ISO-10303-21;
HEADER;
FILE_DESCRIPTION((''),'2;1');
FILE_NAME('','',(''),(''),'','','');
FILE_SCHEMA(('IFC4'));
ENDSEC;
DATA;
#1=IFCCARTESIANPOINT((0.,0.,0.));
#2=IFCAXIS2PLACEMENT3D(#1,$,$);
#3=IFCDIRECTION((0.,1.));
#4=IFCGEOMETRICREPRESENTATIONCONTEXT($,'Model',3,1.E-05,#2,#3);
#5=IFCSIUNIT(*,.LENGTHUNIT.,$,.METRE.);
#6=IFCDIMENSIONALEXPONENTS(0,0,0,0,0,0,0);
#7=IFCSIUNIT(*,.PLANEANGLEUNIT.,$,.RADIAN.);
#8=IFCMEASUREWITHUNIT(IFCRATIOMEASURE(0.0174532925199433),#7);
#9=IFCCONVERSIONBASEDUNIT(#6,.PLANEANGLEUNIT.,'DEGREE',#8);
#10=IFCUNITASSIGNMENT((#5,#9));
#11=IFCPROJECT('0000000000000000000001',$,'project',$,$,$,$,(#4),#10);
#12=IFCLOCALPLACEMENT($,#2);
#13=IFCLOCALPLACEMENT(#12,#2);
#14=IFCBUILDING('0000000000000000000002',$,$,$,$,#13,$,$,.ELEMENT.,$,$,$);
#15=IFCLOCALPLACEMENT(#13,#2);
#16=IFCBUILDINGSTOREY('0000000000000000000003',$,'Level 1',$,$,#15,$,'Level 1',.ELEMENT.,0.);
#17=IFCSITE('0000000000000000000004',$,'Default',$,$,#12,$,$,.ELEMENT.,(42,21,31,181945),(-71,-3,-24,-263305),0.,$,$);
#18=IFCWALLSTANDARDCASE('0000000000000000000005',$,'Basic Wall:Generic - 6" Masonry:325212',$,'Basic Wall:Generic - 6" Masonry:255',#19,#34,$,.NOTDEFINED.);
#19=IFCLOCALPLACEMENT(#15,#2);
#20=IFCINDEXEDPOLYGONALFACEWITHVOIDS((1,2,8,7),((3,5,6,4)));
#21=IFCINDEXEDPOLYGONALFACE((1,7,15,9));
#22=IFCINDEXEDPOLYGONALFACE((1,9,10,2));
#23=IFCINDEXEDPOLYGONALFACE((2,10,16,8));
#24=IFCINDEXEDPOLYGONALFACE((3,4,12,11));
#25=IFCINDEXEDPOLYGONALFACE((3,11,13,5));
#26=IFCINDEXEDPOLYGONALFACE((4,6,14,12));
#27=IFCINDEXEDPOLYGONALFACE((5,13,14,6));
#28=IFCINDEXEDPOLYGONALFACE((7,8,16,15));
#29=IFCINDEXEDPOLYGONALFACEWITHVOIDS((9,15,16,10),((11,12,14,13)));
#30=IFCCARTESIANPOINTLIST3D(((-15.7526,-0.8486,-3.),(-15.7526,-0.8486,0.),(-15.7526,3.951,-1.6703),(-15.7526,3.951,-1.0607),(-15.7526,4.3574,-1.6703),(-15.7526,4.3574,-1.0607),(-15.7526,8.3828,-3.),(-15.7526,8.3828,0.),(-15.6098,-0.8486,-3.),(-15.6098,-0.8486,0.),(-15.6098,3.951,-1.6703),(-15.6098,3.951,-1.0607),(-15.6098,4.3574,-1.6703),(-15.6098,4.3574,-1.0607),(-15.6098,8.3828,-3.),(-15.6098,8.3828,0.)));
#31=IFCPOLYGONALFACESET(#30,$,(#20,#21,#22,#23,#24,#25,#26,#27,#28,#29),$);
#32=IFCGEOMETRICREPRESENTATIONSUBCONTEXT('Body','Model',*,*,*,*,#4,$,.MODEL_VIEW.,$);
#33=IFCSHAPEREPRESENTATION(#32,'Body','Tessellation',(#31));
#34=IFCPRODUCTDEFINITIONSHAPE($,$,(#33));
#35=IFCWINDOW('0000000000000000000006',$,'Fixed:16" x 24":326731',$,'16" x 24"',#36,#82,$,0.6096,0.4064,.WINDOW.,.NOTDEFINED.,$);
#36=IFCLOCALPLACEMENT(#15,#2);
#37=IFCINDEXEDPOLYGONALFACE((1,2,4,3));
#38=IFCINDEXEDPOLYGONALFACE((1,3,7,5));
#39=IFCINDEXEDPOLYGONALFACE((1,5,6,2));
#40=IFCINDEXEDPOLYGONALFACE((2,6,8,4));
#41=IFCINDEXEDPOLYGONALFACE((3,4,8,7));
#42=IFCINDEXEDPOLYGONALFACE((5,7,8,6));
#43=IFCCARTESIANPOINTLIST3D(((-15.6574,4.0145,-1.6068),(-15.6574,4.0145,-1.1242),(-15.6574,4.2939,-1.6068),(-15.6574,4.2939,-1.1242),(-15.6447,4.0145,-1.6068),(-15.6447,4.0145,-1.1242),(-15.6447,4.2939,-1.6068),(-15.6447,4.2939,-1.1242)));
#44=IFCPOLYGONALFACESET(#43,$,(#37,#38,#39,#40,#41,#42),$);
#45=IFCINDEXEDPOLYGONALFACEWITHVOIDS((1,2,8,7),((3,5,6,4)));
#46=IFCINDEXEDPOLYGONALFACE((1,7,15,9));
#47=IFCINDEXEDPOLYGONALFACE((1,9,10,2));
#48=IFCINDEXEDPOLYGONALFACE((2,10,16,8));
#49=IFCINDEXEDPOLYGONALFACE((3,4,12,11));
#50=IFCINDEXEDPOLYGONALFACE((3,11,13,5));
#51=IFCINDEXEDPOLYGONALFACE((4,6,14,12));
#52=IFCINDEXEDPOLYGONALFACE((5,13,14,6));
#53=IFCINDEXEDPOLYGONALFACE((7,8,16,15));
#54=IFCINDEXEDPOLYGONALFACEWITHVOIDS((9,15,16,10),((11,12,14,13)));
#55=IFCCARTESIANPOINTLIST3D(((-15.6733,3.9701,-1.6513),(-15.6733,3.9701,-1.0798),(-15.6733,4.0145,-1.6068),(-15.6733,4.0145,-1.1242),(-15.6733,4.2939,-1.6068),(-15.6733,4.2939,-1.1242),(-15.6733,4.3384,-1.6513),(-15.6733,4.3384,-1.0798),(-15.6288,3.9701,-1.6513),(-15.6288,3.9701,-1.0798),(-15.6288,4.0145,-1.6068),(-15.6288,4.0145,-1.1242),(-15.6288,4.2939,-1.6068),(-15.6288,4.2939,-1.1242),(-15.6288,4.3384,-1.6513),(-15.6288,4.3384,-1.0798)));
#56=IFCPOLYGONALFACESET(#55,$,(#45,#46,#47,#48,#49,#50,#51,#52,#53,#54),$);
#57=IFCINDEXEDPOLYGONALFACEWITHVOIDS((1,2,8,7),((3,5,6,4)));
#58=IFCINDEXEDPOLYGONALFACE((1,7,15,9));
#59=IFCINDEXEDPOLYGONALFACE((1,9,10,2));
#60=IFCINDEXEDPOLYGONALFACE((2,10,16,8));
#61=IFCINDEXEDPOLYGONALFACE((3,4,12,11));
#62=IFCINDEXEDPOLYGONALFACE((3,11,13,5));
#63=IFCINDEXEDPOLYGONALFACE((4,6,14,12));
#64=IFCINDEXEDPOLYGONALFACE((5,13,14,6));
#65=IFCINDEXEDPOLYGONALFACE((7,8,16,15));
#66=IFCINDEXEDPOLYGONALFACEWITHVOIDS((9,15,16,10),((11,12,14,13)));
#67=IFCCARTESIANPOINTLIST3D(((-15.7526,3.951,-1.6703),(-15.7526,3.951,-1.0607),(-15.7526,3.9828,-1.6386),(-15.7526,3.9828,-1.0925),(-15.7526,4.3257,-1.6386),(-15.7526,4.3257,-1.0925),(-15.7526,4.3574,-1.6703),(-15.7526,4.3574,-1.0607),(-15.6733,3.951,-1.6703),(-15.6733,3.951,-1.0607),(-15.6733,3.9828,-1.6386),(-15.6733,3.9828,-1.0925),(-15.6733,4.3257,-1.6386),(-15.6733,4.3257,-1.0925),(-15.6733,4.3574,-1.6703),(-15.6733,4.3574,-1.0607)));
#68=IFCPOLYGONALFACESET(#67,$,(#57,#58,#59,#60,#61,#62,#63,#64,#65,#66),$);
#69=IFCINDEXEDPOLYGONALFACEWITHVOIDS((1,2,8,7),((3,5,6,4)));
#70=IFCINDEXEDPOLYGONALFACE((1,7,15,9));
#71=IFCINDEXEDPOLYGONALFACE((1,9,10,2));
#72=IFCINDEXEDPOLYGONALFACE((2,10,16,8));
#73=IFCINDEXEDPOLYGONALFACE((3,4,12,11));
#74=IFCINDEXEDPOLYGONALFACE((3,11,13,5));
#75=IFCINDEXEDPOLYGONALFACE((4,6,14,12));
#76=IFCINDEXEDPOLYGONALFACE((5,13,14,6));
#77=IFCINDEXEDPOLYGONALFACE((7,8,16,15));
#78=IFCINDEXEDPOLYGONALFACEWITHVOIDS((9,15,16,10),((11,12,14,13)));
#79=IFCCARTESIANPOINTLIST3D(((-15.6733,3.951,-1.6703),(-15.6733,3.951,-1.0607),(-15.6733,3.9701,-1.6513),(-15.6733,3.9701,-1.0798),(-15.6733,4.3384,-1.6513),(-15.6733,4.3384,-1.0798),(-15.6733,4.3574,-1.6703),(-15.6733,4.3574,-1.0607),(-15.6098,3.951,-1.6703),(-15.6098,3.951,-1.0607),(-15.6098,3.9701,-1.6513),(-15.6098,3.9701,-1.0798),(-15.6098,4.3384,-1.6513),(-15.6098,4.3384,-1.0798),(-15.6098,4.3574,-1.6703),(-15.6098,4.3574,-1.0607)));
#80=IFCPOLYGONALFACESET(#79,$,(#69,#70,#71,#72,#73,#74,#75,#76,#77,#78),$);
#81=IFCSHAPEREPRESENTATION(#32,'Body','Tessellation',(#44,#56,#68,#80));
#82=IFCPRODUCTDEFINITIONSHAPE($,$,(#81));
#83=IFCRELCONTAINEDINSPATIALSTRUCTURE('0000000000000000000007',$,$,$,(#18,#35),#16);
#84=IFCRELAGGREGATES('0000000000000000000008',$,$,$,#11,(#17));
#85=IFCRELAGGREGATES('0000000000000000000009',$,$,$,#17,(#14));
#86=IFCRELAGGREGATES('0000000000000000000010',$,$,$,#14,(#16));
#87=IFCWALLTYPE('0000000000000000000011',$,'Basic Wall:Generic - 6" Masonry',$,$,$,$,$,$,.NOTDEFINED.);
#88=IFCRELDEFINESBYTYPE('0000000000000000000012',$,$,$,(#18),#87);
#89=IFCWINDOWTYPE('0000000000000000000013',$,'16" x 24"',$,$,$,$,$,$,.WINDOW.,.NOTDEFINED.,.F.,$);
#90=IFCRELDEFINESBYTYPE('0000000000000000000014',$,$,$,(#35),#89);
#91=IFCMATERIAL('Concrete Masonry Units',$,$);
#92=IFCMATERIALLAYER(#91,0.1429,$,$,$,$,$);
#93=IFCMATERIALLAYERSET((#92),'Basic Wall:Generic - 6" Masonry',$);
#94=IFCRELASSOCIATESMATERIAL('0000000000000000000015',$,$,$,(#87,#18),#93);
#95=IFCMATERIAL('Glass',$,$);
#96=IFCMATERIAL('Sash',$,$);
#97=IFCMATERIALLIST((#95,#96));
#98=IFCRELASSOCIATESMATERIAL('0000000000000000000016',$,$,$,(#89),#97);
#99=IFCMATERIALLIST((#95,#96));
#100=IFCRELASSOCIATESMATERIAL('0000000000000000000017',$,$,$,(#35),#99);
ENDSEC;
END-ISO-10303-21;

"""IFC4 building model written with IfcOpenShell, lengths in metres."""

from ifc_helpers import new_model, entity, si_unit, converted_unit, direction, frame, frame_2d, origin, place, context, subcontext, project, spatial, polyline, rectangle, outline, extrude, source, transform, mapped, material, material_list, layer, layer_set, layer_usage, type_object, type_shapes, element, fill, save


model = new_model("IFC4")

# Units and contexts
model_context = context("Model", 3, precision=1e-05, world=origin(), true_north=direction((0.0, 1.0)))
body_context = subcontext(model_context, "Body", "Model", "MODEL_VIEW")
ifc_project = project(units=[si_unit("LENGTHUNIT", "METRE"), converted_unit("PLANEANGLEUNIT", "DEGREE", entity("IfcRatioMeasure", 0.0174532925199433), si_unit("PLANEANGLEUNIT", "RADIAN"), dimensions=[0, 0, 0, 0, 0, 0, 0])], contexts=[model_context])

# Site, building, storey
site_placement = place(None, origin())
site = spatial("IfcSite", under=ifc_project, at=site_placement, Name="Default", CompositionType="ELEMENT", RefLatitude=(42, 21, 31, 181945), RefLongitude=(-71, -3, -24, -263305), RefElevation=0.0)
building_placement = place(site_placement, origin())
building = spatial("IfcBuilding", under=site, at=building_placement, CompositionType="ELEMENT")
storey_placement = place(building_placement, origin())
storey = spatial("IfcBuildingStorey", under=building, at=storey_placement, Name="Level 1", LongName="Level 1", CompositionType="ELEMENT", Elevation=0.0)

# Shared definitions
ifc_material_1 = material(Name="Concrete Masonry Units")
ifc_layer = layer(ifc_material_1, 0.1429)
ifc_layer_set = layer_set([ifc_layer], Name="Basic Wall:Generic - 6\" Masonry")
wall_type = type_object("IfcWallType", Name="Basic Wall:Generic - 6\" Masonry", PredefinedType="NOTDEFINED", material=ifc_layer_set)
ifc_material_2 = material(Name="Glass")
ifc_material_3 = material(Name="Sash")
ifc_material_list_1 = material_list([ifc_material_2, ifc_material_3])
window_type = type_object("IfcWindowType", Name="16\" x 24\"", ParameterTakesPrecedence=False, PartitioningType="NOTDEFINED", PredefinedType="WINDOW", material=ifc_material_list_1)
shared_shape = source(origin(), body_context, "Body", "SweptSolid", [
    extrude(rectangle(XDim=0.0127, YDim=0.2794, at=frame_2d((0.0, 0.0), x_axis=(1.0, 0.0))), frame((0.2032, 0.1016, 0.0635), z_axis=(0.0, 0.0, 1.0), x_axis=(0.0, 1.0, 0.0)), (0.0, 0.0, 1.0), 0.4826),
    extrude(outline(polyline([(-0.1841, -0.2858), (0.1841, -0.2858), (0.1841, 0.2858), (-0.1841, 0.2858), (-0.1841, -0.2858)]), holes=[polyline([(-0.1397, -0.2413), (-0.1397, 0.2413), (0.1397, 0.2413), (0.1397, -0.2413), (-0.1397, -0.2413)])]), frame((0.2032, 0.0794, 0.3048), z_axis=(0.0, 1.0, 0.0), x_axis=(1.0, 0.0, 0.0)), (0.0, 0.0, 1.0), 0.0445),
    extrude(outline(polyline([(-0.2032, -0.3048), (0.2032, -0.3048), (0.2032, 0.3048), (-0.2032, 0.3048), (-0.2032, -0.3048)]), holes=[polyline([(-0.1715, -0.273), (-0.1715, 0.2731), (0.1714, 0.2731), (0.1714, -0.273), (-0.1715, -0.273)])]), frame((0.2032, 0.0, 0.3048), z_axis=(0.0, 1.0, 0.0), x_axis=(1.0, 0.0, 0.0)), (0.0, 0.0, 1.0), 0.0794),
    extrude(outline(polyline([(-0.3048, -0.2032), (0.3048, -0.2032), (0.3048, 0.2032), (-0.3048, 0.2032), (-0.3048, -0.2032)]), holes=[polyline([(-0.2857, -0.1841), (-0.2857, 0.1842), (0.2858, 0.1842), (0.2858, -0.1841), (-0.2857, -0.1841)])]), frame((0.2032, 0.0794, 0.3048), z_axis=(0.0, 1.0, 0.0), x_axis=(0.0, 0.0, -1.0)), (0.0, 0.0, 1.0), 0.0635),
])
type_shapes(window_type, [shared_shape])

# Wall, opening, window
ifc_layer_usage_1 = layer_usage(ifc_layer_set, "AXIS2", "NEGATIVE", 0.0714)
wall_1_placement = place(storey_placement, frame((-15.6812, -0.8486, -3.0), z_axis=(0.0, 0.0, 1.0), x_axis=(0.0, 1.0, 0.0)))
wall_1 = element("IfcWallStandardCase", 1, at=wall_1_placement, inside=storey, type_object=wall_type, material=ifc_layer_usage_1, Name="Basic Wall:Generic - 6\" Masonry:325212", ObjectType="Basic Wall:Generic - 6\" Masonry:255", PredefinedType="NOTDEFINED", context=body_context, shape_type="SweptSolid", body=[
    extrude(rectangle(XDim=9.2314, YDim=0.1429, at=frame_2d((4.6157, 0.0), x_axis=(-1.0, 0.0))), origin(), (0.0, 0.0, 1.0), 3.0),
])
opening_1_placement = place(wall_1_placement, frame((5.206, 0.0714, 1.3297)))
opening_1 = element("IfcOpeningElement", 2, at=opening_1_placement, cuts=wall_1, ObjectType="Opening", PredefinedType="OPENING", context=body_context, shape_type="SweptSolid", body=[
    extrude(rectangle(XDim=0.6096, YDim=0.4064, at=frame_2d((0.3048, 0.2032), x_axis=(-1.0, 0.0))), frame((0.0, 0.0, 0.0), z_axis=(0.0, -1.0, 0.0), x_axis=(0.0, 0.0, 1.0)), (0.0, 0.0, 1.0), 0.1429),
])
ifc_material_list_2 = material_list([ifc_material_2, ifc_material_3])
window_1_placement = place(opening_1_placement, frame((0.0, 0.0, 0.0), z_axis=(0.0, 0.0, 1.0), x_axis=(-1.0, 0.0, 0.0)))
window_1 = element("IfcWindow", 3, at=window_1_placement, inside=storey, type_object=window_type, material=ifc_material_list_2, Name="Fixed:16\" x 24\":326731", ObjectType="16\" x 24\"", OverallHeight=0.6096, OverallWidth=0.4064, PartitioningType="NOTDEFINED", PredefinedType="WINDOW", context=body_context, shape_type="MappedRepresentation", body=[
    mapped(shared_shape, transform((0.0, 0.0, 0.0), scale=1.0)),
])
fill(opening_1, window_1)

save(model, "model.ifc")
